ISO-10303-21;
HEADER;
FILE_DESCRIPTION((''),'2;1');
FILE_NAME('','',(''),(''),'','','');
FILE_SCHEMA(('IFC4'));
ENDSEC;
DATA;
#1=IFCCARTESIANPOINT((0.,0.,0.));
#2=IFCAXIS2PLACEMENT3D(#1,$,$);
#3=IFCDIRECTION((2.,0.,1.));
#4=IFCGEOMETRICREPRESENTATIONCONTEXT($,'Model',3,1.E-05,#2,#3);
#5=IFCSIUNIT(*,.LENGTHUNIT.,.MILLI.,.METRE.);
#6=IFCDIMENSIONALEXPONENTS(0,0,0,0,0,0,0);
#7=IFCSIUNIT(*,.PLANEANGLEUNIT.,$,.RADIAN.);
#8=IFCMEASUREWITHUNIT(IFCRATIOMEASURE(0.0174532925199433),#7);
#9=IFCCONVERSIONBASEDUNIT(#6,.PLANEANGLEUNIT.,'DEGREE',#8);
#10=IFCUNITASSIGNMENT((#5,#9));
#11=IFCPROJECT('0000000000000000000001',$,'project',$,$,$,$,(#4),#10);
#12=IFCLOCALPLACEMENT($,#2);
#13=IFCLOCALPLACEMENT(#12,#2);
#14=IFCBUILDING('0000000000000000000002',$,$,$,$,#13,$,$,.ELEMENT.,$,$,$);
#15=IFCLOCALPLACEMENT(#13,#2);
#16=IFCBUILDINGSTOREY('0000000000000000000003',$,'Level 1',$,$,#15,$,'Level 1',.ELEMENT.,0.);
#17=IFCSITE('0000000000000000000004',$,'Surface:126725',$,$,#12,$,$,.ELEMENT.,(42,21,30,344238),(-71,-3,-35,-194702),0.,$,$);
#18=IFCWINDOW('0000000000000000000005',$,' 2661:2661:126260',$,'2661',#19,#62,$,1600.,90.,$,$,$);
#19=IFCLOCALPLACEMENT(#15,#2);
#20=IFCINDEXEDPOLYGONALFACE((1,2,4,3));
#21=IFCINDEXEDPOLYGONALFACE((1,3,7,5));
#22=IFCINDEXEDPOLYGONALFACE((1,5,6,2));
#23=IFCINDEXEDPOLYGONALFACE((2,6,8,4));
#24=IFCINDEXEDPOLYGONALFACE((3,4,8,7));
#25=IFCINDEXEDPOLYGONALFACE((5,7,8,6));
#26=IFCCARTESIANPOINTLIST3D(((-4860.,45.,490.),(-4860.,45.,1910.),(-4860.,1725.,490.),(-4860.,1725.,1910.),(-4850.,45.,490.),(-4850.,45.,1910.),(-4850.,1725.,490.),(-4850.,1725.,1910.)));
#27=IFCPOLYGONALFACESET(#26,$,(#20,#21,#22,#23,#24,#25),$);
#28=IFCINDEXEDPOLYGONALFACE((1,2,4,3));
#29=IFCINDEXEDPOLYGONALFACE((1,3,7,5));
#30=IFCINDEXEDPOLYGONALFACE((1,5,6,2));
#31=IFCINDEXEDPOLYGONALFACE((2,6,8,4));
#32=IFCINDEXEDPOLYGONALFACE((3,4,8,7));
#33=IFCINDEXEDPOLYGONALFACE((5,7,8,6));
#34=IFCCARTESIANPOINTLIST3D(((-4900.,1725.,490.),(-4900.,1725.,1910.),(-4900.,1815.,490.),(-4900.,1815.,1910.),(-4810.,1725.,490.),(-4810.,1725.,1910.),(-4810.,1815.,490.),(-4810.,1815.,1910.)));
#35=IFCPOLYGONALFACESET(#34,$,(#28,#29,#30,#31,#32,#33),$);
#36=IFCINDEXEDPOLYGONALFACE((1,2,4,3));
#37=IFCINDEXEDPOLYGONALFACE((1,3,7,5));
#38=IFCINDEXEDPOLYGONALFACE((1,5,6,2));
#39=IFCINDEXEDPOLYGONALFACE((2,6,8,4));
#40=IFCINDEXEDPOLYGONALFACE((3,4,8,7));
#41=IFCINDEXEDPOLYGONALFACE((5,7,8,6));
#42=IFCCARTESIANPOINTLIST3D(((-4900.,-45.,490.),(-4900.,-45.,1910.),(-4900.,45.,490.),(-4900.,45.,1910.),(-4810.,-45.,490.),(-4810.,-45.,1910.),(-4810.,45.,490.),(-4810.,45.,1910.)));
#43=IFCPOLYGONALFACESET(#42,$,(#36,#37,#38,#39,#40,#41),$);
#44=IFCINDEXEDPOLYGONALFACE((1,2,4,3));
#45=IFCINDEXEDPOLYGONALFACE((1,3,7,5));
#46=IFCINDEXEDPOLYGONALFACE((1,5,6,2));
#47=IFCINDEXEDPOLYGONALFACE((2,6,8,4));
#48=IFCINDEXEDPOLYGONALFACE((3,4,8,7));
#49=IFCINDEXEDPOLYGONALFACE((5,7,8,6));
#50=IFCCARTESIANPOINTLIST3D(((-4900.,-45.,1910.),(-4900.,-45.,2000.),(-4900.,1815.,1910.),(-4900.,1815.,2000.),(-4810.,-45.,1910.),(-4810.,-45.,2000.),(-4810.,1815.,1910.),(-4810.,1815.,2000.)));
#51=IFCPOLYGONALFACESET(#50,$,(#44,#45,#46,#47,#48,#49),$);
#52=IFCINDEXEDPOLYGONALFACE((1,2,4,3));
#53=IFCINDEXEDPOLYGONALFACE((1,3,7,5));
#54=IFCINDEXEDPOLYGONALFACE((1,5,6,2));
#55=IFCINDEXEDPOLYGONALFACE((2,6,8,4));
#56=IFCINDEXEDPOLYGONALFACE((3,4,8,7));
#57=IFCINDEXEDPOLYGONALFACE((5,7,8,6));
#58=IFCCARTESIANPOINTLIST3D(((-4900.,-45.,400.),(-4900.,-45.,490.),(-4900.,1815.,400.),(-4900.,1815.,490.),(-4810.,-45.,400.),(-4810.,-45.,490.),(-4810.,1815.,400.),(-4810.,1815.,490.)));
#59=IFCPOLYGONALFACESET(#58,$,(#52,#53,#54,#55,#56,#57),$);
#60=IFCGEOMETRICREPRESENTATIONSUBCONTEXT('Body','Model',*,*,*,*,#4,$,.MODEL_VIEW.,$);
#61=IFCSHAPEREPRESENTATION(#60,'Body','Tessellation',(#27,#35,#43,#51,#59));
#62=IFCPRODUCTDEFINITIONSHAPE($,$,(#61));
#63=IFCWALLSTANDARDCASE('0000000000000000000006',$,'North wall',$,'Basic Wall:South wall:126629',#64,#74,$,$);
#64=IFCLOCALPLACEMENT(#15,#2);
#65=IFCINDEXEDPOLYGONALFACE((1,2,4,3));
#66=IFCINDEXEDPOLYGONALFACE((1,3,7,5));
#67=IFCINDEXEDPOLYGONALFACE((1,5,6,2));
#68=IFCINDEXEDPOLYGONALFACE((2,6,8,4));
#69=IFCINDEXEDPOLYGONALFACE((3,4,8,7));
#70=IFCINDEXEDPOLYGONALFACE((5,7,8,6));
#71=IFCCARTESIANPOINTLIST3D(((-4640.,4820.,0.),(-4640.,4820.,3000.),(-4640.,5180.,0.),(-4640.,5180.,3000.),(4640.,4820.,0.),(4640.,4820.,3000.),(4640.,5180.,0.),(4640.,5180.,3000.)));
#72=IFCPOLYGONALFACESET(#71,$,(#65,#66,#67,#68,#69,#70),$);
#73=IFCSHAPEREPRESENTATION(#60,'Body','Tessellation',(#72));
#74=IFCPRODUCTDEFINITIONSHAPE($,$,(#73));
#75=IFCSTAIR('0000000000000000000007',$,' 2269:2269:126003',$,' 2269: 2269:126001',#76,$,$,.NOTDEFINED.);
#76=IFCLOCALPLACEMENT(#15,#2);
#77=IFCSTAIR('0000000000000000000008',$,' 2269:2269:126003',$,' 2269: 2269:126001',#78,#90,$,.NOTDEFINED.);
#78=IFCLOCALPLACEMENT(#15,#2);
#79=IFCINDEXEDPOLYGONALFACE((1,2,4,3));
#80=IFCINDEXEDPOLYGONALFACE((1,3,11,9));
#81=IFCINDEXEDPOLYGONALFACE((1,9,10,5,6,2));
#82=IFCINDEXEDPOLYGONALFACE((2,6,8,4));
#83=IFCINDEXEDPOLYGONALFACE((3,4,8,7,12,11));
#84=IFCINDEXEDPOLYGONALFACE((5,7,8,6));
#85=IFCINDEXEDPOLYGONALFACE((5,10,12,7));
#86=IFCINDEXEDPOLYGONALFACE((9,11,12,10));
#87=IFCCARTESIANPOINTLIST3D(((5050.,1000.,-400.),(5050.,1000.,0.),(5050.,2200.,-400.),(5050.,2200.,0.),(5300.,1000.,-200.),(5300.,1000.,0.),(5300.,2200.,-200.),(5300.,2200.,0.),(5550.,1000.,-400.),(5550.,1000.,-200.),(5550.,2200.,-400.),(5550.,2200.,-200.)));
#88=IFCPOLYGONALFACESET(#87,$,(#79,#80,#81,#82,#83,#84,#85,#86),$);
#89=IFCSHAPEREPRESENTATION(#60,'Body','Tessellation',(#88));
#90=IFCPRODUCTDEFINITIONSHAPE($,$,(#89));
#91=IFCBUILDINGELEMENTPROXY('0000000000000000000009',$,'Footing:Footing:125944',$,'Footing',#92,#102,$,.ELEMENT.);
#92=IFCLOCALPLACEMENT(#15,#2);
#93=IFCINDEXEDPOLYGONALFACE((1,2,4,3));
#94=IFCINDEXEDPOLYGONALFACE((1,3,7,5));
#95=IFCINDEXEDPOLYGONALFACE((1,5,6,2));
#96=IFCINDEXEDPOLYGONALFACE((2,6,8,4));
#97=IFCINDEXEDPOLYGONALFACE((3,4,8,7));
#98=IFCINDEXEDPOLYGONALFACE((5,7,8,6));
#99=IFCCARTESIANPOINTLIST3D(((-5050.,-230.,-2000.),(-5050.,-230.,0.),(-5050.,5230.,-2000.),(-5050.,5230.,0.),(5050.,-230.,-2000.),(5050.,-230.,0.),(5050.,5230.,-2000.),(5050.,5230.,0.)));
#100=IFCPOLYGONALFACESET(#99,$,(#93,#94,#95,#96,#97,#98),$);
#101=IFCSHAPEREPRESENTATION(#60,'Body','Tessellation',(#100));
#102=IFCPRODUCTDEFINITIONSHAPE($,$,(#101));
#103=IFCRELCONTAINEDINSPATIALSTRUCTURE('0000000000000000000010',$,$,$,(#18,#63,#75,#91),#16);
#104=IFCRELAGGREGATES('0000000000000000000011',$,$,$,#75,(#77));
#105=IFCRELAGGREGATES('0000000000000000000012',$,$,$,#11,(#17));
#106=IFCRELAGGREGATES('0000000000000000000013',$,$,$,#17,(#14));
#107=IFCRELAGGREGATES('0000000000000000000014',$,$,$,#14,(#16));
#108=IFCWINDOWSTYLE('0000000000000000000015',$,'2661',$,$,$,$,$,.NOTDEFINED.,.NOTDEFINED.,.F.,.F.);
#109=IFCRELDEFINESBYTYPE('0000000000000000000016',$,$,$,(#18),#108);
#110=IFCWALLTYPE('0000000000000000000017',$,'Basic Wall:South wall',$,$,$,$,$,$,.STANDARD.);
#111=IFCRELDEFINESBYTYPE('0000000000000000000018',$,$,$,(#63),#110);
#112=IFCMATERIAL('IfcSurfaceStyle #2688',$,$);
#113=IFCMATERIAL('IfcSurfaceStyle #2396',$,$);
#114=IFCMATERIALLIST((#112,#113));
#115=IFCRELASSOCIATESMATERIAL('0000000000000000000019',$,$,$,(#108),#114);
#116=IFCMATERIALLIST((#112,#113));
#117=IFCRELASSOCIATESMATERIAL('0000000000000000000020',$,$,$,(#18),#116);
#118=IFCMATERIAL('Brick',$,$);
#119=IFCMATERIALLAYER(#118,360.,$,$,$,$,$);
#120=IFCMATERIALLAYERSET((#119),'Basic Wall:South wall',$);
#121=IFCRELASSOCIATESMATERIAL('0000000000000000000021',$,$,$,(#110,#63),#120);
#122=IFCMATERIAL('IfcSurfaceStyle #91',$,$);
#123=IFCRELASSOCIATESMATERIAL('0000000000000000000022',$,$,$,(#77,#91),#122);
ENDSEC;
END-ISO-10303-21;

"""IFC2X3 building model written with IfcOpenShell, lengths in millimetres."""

from ifc_helpers import new_model, entity, si_unit, converted_unit, direction, frame, frame_2d, origin, origin_2d_with_axis, place, context, subcontext, project, spatial, polyline, rectangle, outline, extrude, source, transform, mapped, material, material_list, layer, layer_set, layer_usage, type_object, type_shapes, element, aggregate, save


model = new_model("IFC2X3")

# Units and contexts
model_context = context("Model", 3, precision=1e-05, world=origin(), true_north=direction((2.0, 0.0, 1.0)))
body_context = subcontext(model_context, "Body", "Model", "MODEL_VIEW")
ifc_project = project(units=[si_unit("LENGTHUNIT", "METRE", prefix="MILLI"), converted_unit("PLANEANGLEUNIT", "DEGREE", entity("IfcRatioMeasure", 0.0174532925199433), si_unit("PLANEANGLEUNIT", "RADIAN"), dimensions=[0, 0, 0, 0, 0, 0, 0])], contexts=[model_context])

# Site, building, storey
site_placement = place(None, origin())
site = spatial("IfcSite", under=ifc_project, at=site_placement, Name="Surface:126725", CompositionType="ELEMENT", RefLatitude=(42, 21, 30, 344238), RefLongitude=(-71, -3, -35, -194702), RefElevation=0.0)
building_placement = place(site_placement, origin())
building = spatial("IfcBuilding", under=site, at=building_placement, CompositionType="ELEMENT")
storey_placement = place(building_placement, origin())
storey = spatial("IfcBuildingStorey", under=building, at=storey_placement, Name="Level 1", LongName="Level 1", CompositionType="ELEMENT", Elevation=0.0)

# Window
ifc_material_1 = material(Name="IfcSurfaceStyle #2396")
ifc_material_2 = material(Name="IfcSurfaceStyle #2688")
ifc_material_list_1 = material_list([ifc_material_2, ifc_material_1])
ifc_material_list_2 = material_list([ifc_material_2, ifc_material_1])
window_style_1 = type_object("IfcWindowStyle", Name="2661", ConstructionType="NOTDEFINED", OperationType="NOTDEFINED", ParameterTakesPrecedence=False, Sizeable=False, material=ifc_material_list_2)
shared_shape_1 = source(origin(), body_context, "Body", "SweptSolid", [
    extrude(rectangle(XDim=10.0, YDim=1680.0, at=origin_2d_with_axis()), frame((-4855.0, 885.0, 490.0), z_axis=(0.0, 0.0, 1.0), x_axis=(-1.0, 0.0, 0.0)), (0.0, 0.0, 1.0), 1420.0),
    extrude(rectangle(XDim=90.0, YDim=90.0, at=frame_2d((0.0, 0.0), x_axis=(1.0, 0.0))), frame((-4855.0, 1770.0, 490.0), z_axis=(0.0, 0.0, 1.0), x_axis=(-1.0, 0.0, 0.0)), (0.0, 0.0, 1.0), 1420.0),
    extrude(rectangle(XDim=90.0, YDim=90.0, at=origin_2d_with_axis()), frame((-4855.0, 0.0, 490.0), z_axis=(0.0, 0.0, 1.0), x_axis=(-1.0, 0.0, 0.0)), (0.0, 0.0, 1.0), 1420.0),
    extrude(rectangle(XDim=90.0, YDim=1860.0, at=origin_2d_with_axis()), frame((-4855.0, 885.0, 1910.0), z_axis=(0.0, 0.0, 1.0), x_axis=(-1.0, 0.0, 0.0)), (0.0, 0.0, 1.0), 90.0),
    extrude(rectangle(XDim=90.0, YDim=1860.0, at=origin_2d_with_axis()), frame((-4855.0, 885.0, 400.0), z_axis=(0.0, 0.0, 1.0), x_axis=(-1.0, 0.0, 0.0)), (0.0, 0.0, 1.0), 90.0),
])
type_shapes(window_style_1, [shared_shape_1])
window_1_placement = place(storey_placement, origin())
element("IfcWindow", 1, at=window_1_placement, inside=storey, type_object=window_style_1, material=ifc_material_list_1, Name=" 2661:2661:126260", ObjectType="2661", OverallHeight=1600.0, OverallWidth=90.0, context=body_context, shape_type="MappedRepresentation", body=[
    mapped(shared_shape_1, transform((0.0, 0.0, 0.0), scale=1.0)),
])

# Shared definitions
ifc_material_3 = material(Name="Brick")
ifc_layer = layer(ifc_material_3, 360.0)
ifc_layer_set = layer_set([ifc_layer], Name="Basic Wall:South wall")
wall_type = type_object("IfcWallType", Name="Basic Wall:South wall", PredefinedType="STANDARD", material=ifc_layer_set)

# Wall
ifc_layer_usage_1 = layer_usage(ifc_layer_set, "AXIS2", "NEGATIVE", 180.0)
wall_1_placement = place(storey_placement, frame((4640.0, 5000.0, 0.0), z_axis=(0.0, 0.0, 1.0), x_axis=(-1.0, 0.0, 0.0)))
element("IfcWallStandardCase", 2, at=wall_1_placement, inside=storey, type_object=wall_type, material=ifc_layer_usage_1, Name="North wall", ObjectType="Basic Wall:South wall:126629", context=body_context, shape_type="SweptSolid", body=[
    extrude(rectangle(XDim=9280.0, YDim=360.0, at=frame_2d((4640.0, 0.0), x_axis=(-1.0, 0.0))), origin(), (0.0, 0.0, 1.0), 3000.0),
])

# Stairs
stair_1_placement = place(storey_placement, frame((5050.0, 1000.0, -400.0)))
stair_1 = element("IfcStair", 3, at=stair_1_placement, inside=storey, Name=" 2269:2269:126003", ObjectType=" 2269: 2269:126001", ShapeType="NOTDEFINED")
ifc_material_4 = material(Name="IfcSurfaceStyle #91")
stair_2_placement = place(stair_1_placement, origin())
stair_2 = element("IfcStair", 4, at=stair_2_placement, material=ifc_material_4, Name=" 2269:2269:126003", ObjectType=" 2269: 2269:126001", ShapeType="NOTDEFINED", context=body_context, shape_type="SweptSolid", body=[
    extrude(outline(polyline([(-200.0, 0.0), (-200.0, -250.0), (200.0, -250.0), (200.0, 250.0), (0.0, 250.0), (0.0, 0.0), (-200.0, 0.0)])), frame((250.0, 0.0, 200.0), z_axis=(0.0, -1.0, 0.0), x_axis=(0.0, 0.0, -1.0)), (0.0, 0.0, -1.0), 1200.0),
])
aggregate(stair_1, [stair_2])

# Building element proxy
shared_shape_2 = source(origin(), body_context, "Body", "SweptSolid", [
    extrude(rectangle(XDim=5460.0, YDim=10100.0, at=frame_2d((0.0, 0.0), x_axis=(1.0, 0.0))), frame((0.0, 2500.0, -2000.0), z_axis=(0.0, 0.0, 1.0), x_axis=(0.0, 1.0, 0.0)), (0.0, 0.0, 1.0), 2000.0),
])
proxy_placement = place(storey_placement, origin())
element("IfcBuildingElementProxy", 5, at=proxy_placement, inside=storey, material=ifc_material_4, Name="Footing:Footing:125944", ObjectType="Footing", CompositionType="ELEMENT", context=body_context, shape_type="MappedRepresentation", body=[
    mapped(shared_shape_2, transform((0.0, 0.0, 0.0), scale=1.0)),
])

save(model, "model.ifc")
